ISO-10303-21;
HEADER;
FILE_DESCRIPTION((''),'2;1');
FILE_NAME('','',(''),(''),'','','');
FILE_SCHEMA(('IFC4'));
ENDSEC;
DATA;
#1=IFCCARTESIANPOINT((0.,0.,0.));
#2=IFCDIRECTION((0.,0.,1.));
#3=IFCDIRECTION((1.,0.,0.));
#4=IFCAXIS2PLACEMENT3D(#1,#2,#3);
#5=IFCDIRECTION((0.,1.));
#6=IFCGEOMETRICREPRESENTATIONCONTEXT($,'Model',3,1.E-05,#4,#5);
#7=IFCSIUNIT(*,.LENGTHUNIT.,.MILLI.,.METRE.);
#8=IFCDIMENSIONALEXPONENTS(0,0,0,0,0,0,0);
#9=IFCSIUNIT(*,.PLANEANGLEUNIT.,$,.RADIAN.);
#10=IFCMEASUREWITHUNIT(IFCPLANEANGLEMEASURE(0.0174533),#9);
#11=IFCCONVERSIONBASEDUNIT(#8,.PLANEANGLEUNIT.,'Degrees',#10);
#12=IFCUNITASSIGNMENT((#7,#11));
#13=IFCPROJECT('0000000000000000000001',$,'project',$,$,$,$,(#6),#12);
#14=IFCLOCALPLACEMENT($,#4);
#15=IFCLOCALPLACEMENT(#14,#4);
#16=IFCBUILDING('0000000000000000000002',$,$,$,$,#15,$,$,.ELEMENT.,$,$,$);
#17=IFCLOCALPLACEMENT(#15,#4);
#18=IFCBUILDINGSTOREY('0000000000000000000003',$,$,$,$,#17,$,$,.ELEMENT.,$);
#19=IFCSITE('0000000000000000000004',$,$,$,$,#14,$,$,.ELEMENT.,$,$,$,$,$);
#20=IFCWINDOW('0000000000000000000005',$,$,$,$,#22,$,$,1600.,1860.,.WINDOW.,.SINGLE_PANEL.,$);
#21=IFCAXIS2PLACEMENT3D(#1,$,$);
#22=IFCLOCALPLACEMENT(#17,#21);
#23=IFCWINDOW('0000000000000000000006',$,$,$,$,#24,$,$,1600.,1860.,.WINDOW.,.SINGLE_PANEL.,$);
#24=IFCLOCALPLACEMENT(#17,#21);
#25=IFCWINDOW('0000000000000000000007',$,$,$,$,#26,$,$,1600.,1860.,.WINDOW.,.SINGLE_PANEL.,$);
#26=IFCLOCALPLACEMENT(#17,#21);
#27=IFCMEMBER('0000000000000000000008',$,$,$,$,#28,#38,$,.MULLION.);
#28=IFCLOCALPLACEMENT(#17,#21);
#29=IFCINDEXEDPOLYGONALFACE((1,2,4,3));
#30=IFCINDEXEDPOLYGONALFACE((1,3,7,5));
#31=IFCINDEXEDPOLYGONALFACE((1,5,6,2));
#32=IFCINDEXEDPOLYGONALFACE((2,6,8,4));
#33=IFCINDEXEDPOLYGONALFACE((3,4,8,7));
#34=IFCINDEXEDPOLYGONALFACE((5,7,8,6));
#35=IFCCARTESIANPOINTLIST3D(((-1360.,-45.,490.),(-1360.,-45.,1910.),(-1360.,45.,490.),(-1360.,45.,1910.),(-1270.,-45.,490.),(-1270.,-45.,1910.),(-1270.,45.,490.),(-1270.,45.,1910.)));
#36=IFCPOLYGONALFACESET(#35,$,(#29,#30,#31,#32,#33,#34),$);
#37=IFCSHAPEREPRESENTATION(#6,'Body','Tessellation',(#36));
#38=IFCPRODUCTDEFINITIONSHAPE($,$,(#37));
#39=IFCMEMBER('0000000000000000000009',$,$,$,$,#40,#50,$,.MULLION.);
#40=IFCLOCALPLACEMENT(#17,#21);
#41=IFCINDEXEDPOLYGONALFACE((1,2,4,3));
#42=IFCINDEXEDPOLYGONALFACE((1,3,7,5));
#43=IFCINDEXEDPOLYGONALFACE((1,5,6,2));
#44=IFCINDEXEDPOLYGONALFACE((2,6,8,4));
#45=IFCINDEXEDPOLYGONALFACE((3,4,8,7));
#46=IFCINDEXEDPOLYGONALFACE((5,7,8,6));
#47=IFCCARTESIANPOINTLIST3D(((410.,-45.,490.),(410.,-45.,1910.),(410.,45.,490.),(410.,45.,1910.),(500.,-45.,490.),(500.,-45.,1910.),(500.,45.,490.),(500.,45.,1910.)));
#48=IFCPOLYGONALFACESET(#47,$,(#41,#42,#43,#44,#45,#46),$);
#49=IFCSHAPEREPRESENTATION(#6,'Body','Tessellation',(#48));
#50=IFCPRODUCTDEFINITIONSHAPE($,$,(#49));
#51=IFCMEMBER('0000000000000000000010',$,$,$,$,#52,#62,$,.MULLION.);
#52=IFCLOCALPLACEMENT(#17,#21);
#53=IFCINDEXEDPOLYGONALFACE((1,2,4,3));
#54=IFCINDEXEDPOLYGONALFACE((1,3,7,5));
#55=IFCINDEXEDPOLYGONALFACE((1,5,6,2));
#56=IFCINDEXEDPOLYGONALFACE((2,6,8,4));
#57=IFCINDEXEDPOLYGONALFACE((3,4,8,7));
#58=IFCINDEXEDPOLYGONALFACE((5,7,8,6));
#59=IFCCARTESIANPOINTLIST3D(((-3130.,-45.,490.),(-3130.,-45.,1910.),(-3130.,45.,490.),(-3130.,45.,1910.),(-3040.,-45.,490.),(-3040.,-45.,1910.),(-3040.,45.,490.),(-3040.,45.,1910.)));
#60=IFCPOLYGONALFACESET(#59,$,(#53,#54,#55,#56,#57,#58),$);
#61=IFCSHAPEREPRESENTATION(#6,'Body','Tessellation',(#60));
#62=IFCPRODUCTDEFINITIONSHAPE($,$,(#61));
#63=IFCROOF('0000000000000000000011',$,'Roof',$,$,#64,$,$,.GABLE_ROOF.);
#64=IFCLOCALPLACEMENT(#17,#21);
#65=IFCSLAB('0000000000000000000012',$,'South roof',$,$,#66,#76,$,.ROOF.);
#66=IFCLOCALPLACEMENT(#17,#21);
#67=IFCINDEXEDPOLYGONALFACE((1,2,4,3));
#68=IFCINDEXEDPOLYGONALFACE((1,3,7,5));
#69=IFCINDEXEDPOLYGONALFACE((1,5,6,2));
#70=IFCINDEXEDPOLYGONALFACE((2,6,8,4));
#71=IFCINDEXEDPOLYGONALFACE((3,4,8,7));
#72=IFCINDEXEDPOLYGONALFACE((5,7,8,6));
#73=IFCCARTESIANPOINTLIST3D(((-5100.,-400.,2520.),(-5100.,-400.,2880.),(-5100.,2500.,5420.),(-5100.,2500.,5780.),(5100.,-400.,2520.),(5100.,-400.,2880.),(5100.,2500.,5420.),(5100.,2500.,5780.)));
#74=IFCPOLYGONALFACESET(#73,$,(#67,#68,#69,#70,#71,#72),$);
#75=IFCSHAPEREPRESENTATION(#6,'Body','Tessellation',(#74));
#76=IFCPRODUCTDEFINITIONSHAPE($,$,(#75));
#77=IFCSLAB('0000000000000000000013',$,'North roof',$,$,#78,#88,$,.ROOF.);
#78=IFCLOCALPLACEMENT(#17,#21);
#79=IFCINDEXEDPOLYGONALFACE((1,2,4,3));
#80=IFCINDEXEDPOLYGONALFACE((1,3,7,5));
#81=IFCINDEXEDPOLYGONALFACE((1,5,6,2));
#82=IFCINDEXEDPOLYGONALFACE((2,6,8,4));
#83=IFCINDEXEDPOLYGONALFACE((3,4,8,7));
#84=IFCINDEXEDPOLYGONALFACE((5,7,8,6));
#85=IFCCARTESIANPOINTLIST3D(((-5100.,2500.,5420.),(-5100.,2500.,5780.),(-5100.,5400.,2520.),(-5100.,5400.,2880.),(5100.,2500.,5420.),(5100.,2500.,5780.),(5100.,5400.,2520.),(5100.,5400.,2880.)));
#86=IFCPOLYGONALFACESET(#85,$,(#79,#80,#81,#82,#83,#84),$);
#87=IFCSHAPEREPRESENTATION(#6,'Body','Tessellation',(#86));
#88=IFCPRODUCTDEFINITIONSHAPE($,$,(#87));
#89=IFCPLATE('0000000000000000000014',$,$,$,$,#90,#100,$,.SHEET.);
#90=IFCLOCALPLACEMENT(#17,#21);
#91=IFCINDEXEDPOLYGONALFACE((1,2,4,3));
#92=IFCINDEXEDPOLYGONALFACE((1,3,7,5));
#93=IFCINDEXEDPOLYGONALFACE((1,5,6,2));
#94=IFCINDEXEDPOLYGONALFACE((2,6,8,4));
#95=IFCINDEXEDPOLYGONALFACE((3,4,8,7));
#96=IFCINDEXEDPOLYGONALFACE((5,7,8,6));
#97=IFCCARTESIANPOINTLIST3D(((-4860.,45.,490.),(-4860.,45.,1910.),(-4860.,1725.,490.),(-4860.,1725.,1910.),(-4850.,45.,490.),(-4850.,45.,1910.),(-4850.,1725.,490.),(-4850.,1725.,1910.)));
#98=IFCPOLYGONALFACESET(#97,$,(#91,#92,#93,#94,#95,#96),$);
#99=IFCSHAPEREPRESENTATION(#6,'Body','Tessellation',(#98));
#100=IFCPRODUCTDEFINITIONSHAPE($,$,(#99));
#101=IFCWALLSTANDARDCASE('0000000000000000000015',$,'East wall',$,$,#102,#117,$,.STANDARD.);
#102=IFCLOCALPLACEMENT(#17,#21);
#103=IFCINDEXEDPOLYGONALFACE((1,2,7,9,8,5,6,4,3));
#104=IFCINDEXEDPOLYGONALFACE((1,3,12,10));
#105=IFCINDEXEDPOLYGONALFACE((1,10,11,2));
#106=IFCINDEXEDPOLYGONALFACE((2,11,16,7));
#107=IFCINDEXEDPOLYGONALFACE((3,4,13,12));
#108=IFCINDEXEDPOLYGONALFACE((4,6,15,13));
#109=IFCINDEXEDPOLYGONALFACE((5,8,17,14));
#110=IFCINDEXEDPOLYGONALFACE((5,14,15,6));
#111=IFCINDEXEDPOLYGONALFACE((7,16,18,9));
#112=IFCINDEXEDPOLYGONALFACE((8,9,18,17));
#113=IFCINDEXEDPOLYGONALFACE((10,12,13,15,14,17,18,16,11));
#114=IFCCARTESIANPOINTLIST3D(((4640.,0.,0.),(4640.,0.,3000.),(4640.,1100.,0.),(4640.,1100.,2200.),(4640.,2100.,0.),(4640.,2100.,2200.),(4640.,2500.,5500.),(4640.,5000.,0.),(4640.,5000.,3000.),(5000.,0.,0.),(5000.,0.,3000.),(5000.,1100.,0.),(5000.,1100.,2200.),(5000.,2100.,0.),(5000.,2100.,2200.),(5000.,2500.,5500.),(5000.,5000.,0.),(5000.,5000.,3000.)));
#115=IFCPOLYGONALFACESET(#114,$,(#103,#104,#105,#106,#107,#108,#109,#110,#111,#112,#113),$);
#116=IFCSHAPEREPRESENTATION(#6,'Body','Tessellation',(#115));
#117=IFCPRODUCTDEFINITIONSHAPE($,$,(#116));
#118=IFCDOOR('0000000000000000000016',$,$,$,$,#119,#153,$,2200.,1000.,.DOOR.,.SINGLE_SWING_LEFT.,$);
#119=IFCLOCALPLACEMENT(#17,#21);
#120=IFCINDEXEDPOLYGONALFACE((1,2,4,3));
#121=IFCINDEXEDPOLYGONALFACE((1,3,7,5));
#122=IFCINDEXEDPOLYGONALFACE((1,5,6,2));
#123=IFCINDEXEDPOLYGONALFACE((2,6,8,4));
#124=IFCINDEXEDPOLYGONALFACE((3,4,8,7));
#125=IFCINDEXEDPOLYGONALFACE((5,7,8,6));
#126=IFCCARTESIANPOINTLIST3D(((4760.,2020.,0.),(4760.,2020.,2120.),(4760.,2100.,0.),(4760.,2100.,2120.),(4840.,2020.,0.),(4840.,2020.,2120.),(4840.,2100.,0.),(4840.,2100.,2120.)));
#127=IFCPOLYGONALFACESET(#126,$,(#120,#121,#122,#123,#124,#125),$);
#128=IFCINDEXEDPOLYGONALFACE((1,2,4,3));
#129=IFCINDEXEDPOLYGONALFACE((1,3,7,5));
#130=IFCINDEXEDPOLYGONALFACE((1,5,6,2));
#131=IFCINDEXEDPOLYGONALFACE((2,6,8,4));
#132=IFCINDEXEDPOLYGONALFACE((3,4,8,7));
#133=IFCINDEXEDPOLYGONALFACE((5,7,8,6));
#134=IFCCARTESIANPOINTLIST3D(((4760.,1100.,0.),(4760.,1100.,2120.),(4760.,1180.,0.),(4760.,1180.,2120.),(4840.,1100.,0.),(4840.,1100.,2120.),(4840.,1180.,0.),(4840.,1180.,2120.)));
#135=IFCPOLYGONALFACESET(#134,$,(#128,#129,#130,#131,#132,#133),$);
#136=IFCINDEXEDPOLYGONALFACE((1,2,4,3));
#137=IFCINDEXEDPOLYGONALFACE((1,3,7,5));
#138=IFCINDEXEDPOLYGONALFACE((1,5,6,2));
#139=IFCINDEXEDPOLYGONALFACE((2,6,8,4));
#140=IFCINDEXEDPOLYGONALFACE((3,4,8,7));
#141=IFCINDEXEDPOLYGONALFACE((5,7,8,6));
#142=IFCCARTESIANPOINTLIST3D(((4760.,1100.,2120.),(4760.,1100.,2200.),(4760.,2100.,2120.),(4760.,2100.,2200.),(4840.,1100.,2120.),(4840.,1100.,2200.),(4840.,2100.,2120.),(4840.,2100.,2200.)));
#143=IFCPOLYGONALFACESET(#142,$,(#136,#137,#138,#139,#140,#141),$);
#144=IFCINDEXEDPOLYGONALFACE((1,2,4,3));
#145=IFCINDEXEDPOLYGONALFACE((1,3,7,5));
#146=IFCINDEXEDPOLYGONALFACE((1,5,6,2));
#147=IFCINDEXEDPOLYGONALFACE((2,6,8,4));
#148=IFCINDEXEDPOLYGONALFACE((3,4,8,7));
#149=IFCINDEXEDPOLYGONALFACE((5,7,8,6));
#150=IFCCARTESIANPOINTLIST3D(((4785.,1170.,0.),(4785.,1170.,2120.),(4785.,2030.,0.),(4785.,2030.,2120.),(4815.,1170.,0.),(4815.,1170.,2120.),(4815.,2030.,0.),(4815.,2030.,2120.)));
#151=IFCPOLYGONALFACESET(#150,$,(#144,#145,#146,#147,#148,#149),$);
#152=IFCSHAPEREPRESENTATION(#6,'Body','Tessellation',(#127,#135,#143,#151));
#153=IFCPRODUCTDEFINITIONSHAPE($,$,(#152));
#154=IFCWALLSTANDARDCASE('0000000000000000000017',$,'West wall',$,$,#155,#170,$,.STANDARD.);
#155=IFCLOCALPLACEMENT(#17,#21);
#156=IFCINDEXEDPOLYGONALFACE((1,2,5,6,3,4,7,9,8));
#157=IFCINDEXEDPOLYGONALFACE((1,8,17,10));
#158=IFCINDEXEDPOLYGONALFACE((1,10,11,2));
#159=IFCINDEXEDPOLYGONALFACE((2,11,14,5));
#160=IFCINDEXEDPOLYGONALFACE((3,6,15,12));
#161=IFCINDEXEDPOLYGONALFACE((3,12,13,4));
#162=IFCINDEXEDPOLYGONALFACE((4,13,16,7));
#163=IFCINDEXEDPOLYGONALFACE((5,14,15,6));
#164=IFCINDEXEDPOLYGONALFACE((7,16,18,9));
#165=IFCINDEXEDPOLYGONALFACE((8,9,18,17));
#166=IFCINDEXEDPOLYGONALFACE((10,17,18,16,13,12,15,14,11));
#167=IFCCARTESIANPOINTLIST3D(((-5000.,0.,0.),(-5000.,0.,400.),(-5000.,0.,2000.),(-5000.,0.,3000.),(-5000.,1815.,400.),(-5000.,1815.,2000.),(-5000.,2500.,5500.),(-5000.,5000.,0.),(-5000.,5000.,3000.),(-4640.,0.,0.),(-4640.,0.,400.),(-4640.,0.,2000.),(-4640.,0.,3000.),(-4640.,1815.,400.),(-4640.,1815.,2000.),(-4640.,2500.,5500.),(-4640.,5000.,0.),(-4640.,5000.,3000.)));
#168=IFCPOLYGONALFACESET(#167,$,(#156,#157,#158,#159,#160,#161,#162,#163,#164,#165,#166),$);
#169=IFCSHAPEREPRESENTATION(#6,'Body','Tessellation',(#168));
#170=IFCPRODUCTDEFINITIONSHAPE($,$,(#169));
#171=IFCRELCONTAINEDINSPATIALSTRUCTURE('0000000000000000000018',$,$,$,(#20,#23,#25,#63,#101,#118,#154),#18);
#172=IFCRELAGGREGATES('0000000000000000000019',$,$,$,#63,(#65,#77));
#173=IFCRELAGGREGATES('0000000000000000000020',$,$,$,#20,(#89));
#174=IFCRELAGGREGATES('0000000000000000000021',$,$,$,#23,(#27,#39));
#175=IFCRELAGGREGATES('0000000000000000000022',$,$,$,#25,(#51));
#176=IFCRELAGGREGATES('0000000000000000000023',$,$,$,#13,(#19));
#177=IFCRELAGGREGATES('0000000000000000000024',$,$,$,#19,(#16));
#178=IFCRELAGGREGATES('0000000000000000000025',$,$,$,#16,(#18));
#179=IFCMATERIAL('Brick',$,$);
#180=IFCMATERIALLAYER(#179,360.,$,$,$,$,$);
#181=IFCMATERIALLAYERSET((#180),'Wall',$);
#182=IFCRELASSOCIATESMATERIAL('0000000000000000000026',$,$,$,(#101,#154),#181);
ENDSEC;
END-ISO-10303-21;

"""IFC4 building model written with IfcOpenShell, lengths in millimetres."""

from ifc_helpers import new_model, entity, si_unit, converted_unit, direction, frame, origin_with_axes, place, context, project, spatial, polyline, outline, extrude, clip, halfspace, source, transform, mapped, material, layer, layer_set, layer_usage, element, fill, aggregate, save


model = new_model("IFC4")

# Units and contexts
model_context = context("Model", 3, precision=1e-05, world=origin_with_axes(), true_north=direction((0.0, 1.0)))
ifc_project = project(units=[si_unit("LENGTHUNIT", "METRE", prefix="MILLI"), converted_unit("PLANEANGLEUNIT", "Degrees", entity("IfcPlaneAngleMeasure", 0.0174533), si_unit("PLANEANGLEUNIT", "RADIAN"), dimensions=[0, 0, 0, 0, 0, 0, 0])], contexts=[model_context])

# Site, building, storey
site_placement = place(None, origin_with_axes())
site = spatial("IfcSite", under=ifc_project, at=site_placement, CompositionType="ELEMENT")
building_placement = place(site_placement, origin_with_axes())
building = spatial("IfcBuilding", under=site, at=building_placement, CompositionType="ELEMENT")
storey_placement = place(building_placement, origin_with_axes())
storey = spatial("IfcBuildingStorey", under=building, at=storey_placement, CompositionType="ELEMENT")

# Windows
window_1_placement = place(storey_placement, frame((-4810.0, -45.0, 400.0), z_axis=(0.0, 0.0, 1.0), x_axis=(0.0, 1.0, 0.0)))
window_1 = element("IfcWindow", 1, at=window_1_placement, inside=storey, OverallHeight=1600.0, OverallWidth=1860.0, PartitioningType="SINGLE_PANEL", PredefinedType="WINDOW")
window_2_placement = place(storey_placement, frame((-1360.0, -45.0, 400.0), z_axis=(0.0, 0.0, 1.0), x_axis=(1.0, 0.0, 0.0)))
window_2 = element("IfcWindow", 2, at=window_2_placement, inside=storey, OverallHeight=1600.0, OverallWidth=1860.0, PartitioningType="SINGLE_PANEL", PredefinedType="WINDOW")
window_3_placement = place(storey_placement, frame((-3130.0, -45.0, 400.0), z_axis=(0.0, 0.0, 1.0), x_axis=(1.0, 0.0, 0.0)))
window_3 = element("IfcWindow", 3, at=window_3_placement, inside=storey, OverallHeight=1600.0, OverallWidth=1860.0, PartitioningType="SINGLE_PANEL", PredefinedType="WINDOW")

# Members
shared_shape_1 = source(origin_with_axes(), model_context, "Body", "SweptSolid", [
    extrude(outline(polyline([(-45.0, -45.0), (45.0, -45.0), (45.0, 45.0), (-45.0, 45.0), (-45.0, -45.0), (-45.0, -45.0)])), origin_with_axes(), (0.0, 0.0, 1.0), 1420.0),
])
member_1_placement = place(window_2_placement, frame((45.0, 45.0, 90.0), z_axis=(0.0, 0.0, 1.0), x_axis=(1.0, 0.0, 0.0)))
member_1 = element("IfcMember", 4, at=member_1_placement, PredefinedType="MULLION", context=model_context, shape_type="MappedRepresentation", body=[
    mapped(shared_shape_1, transform((0.0, 0.0, 0.0))),
])
member_2_placement = place(window_2_placement, frame((1815.0, 45.0, 90.0), z_axis=(0.0, 0.0, 1.0), x_axis=(1.0, 0.0, 0.0)))
member_2 = element("IfcMember", 5, at=member_2_placement, PredefinedType="MULLION", context=model_context, shape_type="MappedRepresentation", body=[
    mapped(shared_shape_1, transform((0.0, 0.0, 0.0))),
])
member_3_placement = place(window_3_placement, frame((45.0, 45.0, 90.0), z_axis=(0.0, 0.0, 1.0), x_axis=(1.0, 0.0, 0.0)))
member_3 = element("IfcMember", 6, at=member_3_placement, PredefinedType="MULLION", context=model_context, shape_type="MappedRepresentation", body=[
    mapped(shared_shape_1, transform((0.0, 0.0, 0.0))),
])

# Roof, slabs
roof_placement = place(storey_placement, origin_with_axes())
roof = element("IfcRoof", 7, at=roof_placement, inside=storey, Name="Roof", PredefinedType="GABLE_ROOF")
shared_shape_2 = source(origin_with_axes(), model_context, "Body", "SweptSolid", [
    extrude(outline(polyline([(-5100.0, -180.0), (5100.0, -180.0), (5100.0, 180.0), (-5100.0, 180.0), (-5100.0, -180.0), (-5100.0, -180.0)])), frame((0.0, 0.0, 0.0), z_axis=(0.0, 1.0, 0.0), x_axis=(1.0, 0.0, 0.0)), (0.0, -0.707107, 0.707107), 4101.2),
])
slab_1_placement = place(roof_placement, frame((0.0, -400.0, 2700.0), z_axis=(0.0, 0.0, 1.0), x_axis=(1.0, 0.0, 0.0)))
slab_1 = element("IfcSlab", 8, at=slab_1_placement, Name="South roof", PredefinedType="ROOF", context=model_context, shape_type="MappedRepresentation", body=[
    mapped(shared_shape_2, transform((0.0, 0.0, 0.0))),
])
slab_2_placement = place(roof_placement, frame((0.0, 5400.0, 2700.0), z_axis=(0.0, 0.0, 1.0), x_axis=(-1.0, 0.0, 0.0)))
slab_2 = element("IfcSlab", 9, at=slab_2_placement, Name="North roof", PredefinedType="ROOF", context=model_context, shape_type="MappedRepresentation", body=[
    mapped(shared_shape_2, transform((0.0, 0.0, 0.0))),
])
aggregate(roof, [slab_1, slab_2])

# Plate
plate_1_placement = place(window_1_placement, frame((930.0, 45.0, 90.0), z_axis=(0.0, 0.0, 1.0), x_axis=(1.0, 0.0, 0.0)))
plate_1 = element("IfcPlate", 10, at=plate_1_placement, PredefinedType="SHEET", context=model_context, shape_type="SweptSolid", body=[
    extrude(outline(polyline([(-840.0, -5.0), (840.0, -5.0), (840.0, 5.0), (-840.0, 5.0), (-840.0, -5.0), (-840.0, -5.0)])), origin_with_axes(), (0.0, 0.0, 1.0), 1420.0),
])
aggregate(window_1, [plate_1])
aggregate(window_2, [member_1, member_2])
aggregate(window_3, [member_3])

# Wall, opening, door
ifc_material = material(Name="Brick")
ifc_layer = layer(ifc_material, 360.0)
ifc_layer_set = layer_set([ifc_layer], Name="Wall")
ifc_layer_usage = layer_usage(ifc_layer_set, "AXIS2", "POSITIVE", -180.0)
shared_shape_3 = source(origin_with_axes(), model_context, "Body", "Clipping", [
    clip(clip(extrude(outline(polyline([(-2500.0, -180.0), (2500.0, -180.0), (2500.0, 180.0), (-2500.0, 180.0), (-2500.0, -180.0), (-2500.0, -180.0)])), origin_with_axes(), (0.0, 0.0, 1.0), 6000.0), halfspace(frame((-2500.0, 0.0, 3000.0), z_axis=(-1.0, 0.0, 1.0), x_axis=(1.0, 0.0, 0.0)), False)), halfspace(frame((2500.0, 0.0, 3000.0), z_axis=(1.0, 0.0, 1.0), x_axis=(1.0, 0.0, 0.0)), False)),
])
wall_1_placement = place(storey_placement, frame((4820.0, 2500.0, 0.0), z_axis=(0.0, 0.0, 1.0), x_axis=(0.0, 1.0, 0.0)))
wall_1 = element("IfcWallStandardCase", 11, at=wall_1_placement, inside=storey, material=ifc_layer_usage, Name="East wall", PredefinedType="STANDARD", context=model_context, shape_type="MappedRepresentation", body=[
    mapped(shared_shape_3, transform((0.0, 0.0, 0.0))),
])
opening_1_placement = place(storey_placement, frame((4820.0, 1600.0, 0.0), z_axis=(0.0, 0.0, 1.0), x_axis=(1.0, 0.0, 0.0)))
opening_1 = element("IfcOpeningElement", 12, at=opening_1_placement, cuts=wall_1, PredefinedType="OPENING", context=model_context, shape_type="SweptSolid", body=[
    extrude(outline(polyline([(-500.0, -500.0), (500.0, -500.0), (500.0, 500.0), (-500.0, 500.0), (-500.0, -500.0), (-500.0, -500.0)])), origin_with_axes(), (0.0, 0.0, 1.0), 2200.0),
])
door_placement = place(storey_placement, frame((4800.0, 1600.0, 0.0), z_axis=(0.0, 0.0, 1.0), x_axis=(0.0, 1.0, 0.0)))
door = element("IfcDoor", 13, at=door_placement, inside=storey, OperationType="SINGLE_SWING_LEFT", OverallHeight=2200.0, OverallWidth=1000.0, PredefinedType="DOOR", context=model_context, shape_type="SweptSolid", body=[
    extrude(outline(polyline([(-40.0, -40.0), (40.0, -40.0), (40.0, 40.0), (-40.0, 40.0), (-40.0, -40.0), (-40.0, -40.0)])), frame((460.0, 0.0, 0.0), z_axis=(0.0, 0.0, 1.0), x_axis=(1.0, 0.0, 0.0)), (0.0, 0.0, 1.0), 2120.0),
    extrude(outline(polyline([(-40.0, -40.0), (40.0, -40.0), (40.0, 40.0), (-40.0, 40.0), (-40.0, -40.0), (-40.0, -40.0)])), frame((-460.0, 0.0, 0.0), z_axis=(0.0, 0.0, 1.0), x_axis=(1.0, 0.0, 0.0)), (0.0, 0.0, 1.0), 2120.0),
    extrude(outline(polyline([(-500.0, -40.0), (500.0, -40.0), (500.0, 40.0), (-500.0, 40.0), (-500.0, -40.0), (-500.0, -40.0)])), frame((0.0, 0.0, 2120.0), z_axis=(0.0, 0.0, 1.0), x_axis=(1.0, 0.0, 0.0)), (0.0, 0.0, 1.0), 80.0),
    extrude(outline(polyline([(-430.0, -15.0), (430.0, -15.0), (430.0, 15.0), (-430.0, 15.0), (-430.0, -15.0), (-430.0, -15.0)])), origin_with_axes(), (0.0, 0.0, 1.0), 2120.0),
])
fill(opening_1, door)

# Wall, opening
wall_2_placement = place(storey_placement, frame((-4820.0, 2500.0, 0.0), z_axis=(0.0, 0.0, 1.0), x_axis=(0.0, -1.0, 0.0)))
wall_2 = element("IfcWallStandardCase", 14, at=wall_2_placement, inside=storey, material=ifc_layer_usage, Name="West wall", PredefinedType="STANDARD", context=model_context, shape_type="MappedRepresentation", body=[
    mapped(shared_shape_3, transform((0.0, 0.0, 0.0))),
])
opening_2_placement = place(wall_2_placement, frame((2500.0, 2320.0, 400.0), z_axis=(0.0, 0.0, 1.0), x_axis=(0.0, 1.0, 0.0)))
element("IfcOpeningElement", 15, at=opening_2_placement, cuts=wall_2, PredefinedType="OPENING", context=model_context, shape_type="SweptSolid", body=[
    extrude(outline(polyline([(-3000.0, -1815.0), (3000.0, -1815.0), (3000.0, 1815.0), (-3000.0, 1815.0), (-3000.0, -1815.0), (-3000.0, -1815.0)])), origin_with_axes(), (0.0, 0.0, 1.0), 1600.0),
])

save(model, "model.ifc")
